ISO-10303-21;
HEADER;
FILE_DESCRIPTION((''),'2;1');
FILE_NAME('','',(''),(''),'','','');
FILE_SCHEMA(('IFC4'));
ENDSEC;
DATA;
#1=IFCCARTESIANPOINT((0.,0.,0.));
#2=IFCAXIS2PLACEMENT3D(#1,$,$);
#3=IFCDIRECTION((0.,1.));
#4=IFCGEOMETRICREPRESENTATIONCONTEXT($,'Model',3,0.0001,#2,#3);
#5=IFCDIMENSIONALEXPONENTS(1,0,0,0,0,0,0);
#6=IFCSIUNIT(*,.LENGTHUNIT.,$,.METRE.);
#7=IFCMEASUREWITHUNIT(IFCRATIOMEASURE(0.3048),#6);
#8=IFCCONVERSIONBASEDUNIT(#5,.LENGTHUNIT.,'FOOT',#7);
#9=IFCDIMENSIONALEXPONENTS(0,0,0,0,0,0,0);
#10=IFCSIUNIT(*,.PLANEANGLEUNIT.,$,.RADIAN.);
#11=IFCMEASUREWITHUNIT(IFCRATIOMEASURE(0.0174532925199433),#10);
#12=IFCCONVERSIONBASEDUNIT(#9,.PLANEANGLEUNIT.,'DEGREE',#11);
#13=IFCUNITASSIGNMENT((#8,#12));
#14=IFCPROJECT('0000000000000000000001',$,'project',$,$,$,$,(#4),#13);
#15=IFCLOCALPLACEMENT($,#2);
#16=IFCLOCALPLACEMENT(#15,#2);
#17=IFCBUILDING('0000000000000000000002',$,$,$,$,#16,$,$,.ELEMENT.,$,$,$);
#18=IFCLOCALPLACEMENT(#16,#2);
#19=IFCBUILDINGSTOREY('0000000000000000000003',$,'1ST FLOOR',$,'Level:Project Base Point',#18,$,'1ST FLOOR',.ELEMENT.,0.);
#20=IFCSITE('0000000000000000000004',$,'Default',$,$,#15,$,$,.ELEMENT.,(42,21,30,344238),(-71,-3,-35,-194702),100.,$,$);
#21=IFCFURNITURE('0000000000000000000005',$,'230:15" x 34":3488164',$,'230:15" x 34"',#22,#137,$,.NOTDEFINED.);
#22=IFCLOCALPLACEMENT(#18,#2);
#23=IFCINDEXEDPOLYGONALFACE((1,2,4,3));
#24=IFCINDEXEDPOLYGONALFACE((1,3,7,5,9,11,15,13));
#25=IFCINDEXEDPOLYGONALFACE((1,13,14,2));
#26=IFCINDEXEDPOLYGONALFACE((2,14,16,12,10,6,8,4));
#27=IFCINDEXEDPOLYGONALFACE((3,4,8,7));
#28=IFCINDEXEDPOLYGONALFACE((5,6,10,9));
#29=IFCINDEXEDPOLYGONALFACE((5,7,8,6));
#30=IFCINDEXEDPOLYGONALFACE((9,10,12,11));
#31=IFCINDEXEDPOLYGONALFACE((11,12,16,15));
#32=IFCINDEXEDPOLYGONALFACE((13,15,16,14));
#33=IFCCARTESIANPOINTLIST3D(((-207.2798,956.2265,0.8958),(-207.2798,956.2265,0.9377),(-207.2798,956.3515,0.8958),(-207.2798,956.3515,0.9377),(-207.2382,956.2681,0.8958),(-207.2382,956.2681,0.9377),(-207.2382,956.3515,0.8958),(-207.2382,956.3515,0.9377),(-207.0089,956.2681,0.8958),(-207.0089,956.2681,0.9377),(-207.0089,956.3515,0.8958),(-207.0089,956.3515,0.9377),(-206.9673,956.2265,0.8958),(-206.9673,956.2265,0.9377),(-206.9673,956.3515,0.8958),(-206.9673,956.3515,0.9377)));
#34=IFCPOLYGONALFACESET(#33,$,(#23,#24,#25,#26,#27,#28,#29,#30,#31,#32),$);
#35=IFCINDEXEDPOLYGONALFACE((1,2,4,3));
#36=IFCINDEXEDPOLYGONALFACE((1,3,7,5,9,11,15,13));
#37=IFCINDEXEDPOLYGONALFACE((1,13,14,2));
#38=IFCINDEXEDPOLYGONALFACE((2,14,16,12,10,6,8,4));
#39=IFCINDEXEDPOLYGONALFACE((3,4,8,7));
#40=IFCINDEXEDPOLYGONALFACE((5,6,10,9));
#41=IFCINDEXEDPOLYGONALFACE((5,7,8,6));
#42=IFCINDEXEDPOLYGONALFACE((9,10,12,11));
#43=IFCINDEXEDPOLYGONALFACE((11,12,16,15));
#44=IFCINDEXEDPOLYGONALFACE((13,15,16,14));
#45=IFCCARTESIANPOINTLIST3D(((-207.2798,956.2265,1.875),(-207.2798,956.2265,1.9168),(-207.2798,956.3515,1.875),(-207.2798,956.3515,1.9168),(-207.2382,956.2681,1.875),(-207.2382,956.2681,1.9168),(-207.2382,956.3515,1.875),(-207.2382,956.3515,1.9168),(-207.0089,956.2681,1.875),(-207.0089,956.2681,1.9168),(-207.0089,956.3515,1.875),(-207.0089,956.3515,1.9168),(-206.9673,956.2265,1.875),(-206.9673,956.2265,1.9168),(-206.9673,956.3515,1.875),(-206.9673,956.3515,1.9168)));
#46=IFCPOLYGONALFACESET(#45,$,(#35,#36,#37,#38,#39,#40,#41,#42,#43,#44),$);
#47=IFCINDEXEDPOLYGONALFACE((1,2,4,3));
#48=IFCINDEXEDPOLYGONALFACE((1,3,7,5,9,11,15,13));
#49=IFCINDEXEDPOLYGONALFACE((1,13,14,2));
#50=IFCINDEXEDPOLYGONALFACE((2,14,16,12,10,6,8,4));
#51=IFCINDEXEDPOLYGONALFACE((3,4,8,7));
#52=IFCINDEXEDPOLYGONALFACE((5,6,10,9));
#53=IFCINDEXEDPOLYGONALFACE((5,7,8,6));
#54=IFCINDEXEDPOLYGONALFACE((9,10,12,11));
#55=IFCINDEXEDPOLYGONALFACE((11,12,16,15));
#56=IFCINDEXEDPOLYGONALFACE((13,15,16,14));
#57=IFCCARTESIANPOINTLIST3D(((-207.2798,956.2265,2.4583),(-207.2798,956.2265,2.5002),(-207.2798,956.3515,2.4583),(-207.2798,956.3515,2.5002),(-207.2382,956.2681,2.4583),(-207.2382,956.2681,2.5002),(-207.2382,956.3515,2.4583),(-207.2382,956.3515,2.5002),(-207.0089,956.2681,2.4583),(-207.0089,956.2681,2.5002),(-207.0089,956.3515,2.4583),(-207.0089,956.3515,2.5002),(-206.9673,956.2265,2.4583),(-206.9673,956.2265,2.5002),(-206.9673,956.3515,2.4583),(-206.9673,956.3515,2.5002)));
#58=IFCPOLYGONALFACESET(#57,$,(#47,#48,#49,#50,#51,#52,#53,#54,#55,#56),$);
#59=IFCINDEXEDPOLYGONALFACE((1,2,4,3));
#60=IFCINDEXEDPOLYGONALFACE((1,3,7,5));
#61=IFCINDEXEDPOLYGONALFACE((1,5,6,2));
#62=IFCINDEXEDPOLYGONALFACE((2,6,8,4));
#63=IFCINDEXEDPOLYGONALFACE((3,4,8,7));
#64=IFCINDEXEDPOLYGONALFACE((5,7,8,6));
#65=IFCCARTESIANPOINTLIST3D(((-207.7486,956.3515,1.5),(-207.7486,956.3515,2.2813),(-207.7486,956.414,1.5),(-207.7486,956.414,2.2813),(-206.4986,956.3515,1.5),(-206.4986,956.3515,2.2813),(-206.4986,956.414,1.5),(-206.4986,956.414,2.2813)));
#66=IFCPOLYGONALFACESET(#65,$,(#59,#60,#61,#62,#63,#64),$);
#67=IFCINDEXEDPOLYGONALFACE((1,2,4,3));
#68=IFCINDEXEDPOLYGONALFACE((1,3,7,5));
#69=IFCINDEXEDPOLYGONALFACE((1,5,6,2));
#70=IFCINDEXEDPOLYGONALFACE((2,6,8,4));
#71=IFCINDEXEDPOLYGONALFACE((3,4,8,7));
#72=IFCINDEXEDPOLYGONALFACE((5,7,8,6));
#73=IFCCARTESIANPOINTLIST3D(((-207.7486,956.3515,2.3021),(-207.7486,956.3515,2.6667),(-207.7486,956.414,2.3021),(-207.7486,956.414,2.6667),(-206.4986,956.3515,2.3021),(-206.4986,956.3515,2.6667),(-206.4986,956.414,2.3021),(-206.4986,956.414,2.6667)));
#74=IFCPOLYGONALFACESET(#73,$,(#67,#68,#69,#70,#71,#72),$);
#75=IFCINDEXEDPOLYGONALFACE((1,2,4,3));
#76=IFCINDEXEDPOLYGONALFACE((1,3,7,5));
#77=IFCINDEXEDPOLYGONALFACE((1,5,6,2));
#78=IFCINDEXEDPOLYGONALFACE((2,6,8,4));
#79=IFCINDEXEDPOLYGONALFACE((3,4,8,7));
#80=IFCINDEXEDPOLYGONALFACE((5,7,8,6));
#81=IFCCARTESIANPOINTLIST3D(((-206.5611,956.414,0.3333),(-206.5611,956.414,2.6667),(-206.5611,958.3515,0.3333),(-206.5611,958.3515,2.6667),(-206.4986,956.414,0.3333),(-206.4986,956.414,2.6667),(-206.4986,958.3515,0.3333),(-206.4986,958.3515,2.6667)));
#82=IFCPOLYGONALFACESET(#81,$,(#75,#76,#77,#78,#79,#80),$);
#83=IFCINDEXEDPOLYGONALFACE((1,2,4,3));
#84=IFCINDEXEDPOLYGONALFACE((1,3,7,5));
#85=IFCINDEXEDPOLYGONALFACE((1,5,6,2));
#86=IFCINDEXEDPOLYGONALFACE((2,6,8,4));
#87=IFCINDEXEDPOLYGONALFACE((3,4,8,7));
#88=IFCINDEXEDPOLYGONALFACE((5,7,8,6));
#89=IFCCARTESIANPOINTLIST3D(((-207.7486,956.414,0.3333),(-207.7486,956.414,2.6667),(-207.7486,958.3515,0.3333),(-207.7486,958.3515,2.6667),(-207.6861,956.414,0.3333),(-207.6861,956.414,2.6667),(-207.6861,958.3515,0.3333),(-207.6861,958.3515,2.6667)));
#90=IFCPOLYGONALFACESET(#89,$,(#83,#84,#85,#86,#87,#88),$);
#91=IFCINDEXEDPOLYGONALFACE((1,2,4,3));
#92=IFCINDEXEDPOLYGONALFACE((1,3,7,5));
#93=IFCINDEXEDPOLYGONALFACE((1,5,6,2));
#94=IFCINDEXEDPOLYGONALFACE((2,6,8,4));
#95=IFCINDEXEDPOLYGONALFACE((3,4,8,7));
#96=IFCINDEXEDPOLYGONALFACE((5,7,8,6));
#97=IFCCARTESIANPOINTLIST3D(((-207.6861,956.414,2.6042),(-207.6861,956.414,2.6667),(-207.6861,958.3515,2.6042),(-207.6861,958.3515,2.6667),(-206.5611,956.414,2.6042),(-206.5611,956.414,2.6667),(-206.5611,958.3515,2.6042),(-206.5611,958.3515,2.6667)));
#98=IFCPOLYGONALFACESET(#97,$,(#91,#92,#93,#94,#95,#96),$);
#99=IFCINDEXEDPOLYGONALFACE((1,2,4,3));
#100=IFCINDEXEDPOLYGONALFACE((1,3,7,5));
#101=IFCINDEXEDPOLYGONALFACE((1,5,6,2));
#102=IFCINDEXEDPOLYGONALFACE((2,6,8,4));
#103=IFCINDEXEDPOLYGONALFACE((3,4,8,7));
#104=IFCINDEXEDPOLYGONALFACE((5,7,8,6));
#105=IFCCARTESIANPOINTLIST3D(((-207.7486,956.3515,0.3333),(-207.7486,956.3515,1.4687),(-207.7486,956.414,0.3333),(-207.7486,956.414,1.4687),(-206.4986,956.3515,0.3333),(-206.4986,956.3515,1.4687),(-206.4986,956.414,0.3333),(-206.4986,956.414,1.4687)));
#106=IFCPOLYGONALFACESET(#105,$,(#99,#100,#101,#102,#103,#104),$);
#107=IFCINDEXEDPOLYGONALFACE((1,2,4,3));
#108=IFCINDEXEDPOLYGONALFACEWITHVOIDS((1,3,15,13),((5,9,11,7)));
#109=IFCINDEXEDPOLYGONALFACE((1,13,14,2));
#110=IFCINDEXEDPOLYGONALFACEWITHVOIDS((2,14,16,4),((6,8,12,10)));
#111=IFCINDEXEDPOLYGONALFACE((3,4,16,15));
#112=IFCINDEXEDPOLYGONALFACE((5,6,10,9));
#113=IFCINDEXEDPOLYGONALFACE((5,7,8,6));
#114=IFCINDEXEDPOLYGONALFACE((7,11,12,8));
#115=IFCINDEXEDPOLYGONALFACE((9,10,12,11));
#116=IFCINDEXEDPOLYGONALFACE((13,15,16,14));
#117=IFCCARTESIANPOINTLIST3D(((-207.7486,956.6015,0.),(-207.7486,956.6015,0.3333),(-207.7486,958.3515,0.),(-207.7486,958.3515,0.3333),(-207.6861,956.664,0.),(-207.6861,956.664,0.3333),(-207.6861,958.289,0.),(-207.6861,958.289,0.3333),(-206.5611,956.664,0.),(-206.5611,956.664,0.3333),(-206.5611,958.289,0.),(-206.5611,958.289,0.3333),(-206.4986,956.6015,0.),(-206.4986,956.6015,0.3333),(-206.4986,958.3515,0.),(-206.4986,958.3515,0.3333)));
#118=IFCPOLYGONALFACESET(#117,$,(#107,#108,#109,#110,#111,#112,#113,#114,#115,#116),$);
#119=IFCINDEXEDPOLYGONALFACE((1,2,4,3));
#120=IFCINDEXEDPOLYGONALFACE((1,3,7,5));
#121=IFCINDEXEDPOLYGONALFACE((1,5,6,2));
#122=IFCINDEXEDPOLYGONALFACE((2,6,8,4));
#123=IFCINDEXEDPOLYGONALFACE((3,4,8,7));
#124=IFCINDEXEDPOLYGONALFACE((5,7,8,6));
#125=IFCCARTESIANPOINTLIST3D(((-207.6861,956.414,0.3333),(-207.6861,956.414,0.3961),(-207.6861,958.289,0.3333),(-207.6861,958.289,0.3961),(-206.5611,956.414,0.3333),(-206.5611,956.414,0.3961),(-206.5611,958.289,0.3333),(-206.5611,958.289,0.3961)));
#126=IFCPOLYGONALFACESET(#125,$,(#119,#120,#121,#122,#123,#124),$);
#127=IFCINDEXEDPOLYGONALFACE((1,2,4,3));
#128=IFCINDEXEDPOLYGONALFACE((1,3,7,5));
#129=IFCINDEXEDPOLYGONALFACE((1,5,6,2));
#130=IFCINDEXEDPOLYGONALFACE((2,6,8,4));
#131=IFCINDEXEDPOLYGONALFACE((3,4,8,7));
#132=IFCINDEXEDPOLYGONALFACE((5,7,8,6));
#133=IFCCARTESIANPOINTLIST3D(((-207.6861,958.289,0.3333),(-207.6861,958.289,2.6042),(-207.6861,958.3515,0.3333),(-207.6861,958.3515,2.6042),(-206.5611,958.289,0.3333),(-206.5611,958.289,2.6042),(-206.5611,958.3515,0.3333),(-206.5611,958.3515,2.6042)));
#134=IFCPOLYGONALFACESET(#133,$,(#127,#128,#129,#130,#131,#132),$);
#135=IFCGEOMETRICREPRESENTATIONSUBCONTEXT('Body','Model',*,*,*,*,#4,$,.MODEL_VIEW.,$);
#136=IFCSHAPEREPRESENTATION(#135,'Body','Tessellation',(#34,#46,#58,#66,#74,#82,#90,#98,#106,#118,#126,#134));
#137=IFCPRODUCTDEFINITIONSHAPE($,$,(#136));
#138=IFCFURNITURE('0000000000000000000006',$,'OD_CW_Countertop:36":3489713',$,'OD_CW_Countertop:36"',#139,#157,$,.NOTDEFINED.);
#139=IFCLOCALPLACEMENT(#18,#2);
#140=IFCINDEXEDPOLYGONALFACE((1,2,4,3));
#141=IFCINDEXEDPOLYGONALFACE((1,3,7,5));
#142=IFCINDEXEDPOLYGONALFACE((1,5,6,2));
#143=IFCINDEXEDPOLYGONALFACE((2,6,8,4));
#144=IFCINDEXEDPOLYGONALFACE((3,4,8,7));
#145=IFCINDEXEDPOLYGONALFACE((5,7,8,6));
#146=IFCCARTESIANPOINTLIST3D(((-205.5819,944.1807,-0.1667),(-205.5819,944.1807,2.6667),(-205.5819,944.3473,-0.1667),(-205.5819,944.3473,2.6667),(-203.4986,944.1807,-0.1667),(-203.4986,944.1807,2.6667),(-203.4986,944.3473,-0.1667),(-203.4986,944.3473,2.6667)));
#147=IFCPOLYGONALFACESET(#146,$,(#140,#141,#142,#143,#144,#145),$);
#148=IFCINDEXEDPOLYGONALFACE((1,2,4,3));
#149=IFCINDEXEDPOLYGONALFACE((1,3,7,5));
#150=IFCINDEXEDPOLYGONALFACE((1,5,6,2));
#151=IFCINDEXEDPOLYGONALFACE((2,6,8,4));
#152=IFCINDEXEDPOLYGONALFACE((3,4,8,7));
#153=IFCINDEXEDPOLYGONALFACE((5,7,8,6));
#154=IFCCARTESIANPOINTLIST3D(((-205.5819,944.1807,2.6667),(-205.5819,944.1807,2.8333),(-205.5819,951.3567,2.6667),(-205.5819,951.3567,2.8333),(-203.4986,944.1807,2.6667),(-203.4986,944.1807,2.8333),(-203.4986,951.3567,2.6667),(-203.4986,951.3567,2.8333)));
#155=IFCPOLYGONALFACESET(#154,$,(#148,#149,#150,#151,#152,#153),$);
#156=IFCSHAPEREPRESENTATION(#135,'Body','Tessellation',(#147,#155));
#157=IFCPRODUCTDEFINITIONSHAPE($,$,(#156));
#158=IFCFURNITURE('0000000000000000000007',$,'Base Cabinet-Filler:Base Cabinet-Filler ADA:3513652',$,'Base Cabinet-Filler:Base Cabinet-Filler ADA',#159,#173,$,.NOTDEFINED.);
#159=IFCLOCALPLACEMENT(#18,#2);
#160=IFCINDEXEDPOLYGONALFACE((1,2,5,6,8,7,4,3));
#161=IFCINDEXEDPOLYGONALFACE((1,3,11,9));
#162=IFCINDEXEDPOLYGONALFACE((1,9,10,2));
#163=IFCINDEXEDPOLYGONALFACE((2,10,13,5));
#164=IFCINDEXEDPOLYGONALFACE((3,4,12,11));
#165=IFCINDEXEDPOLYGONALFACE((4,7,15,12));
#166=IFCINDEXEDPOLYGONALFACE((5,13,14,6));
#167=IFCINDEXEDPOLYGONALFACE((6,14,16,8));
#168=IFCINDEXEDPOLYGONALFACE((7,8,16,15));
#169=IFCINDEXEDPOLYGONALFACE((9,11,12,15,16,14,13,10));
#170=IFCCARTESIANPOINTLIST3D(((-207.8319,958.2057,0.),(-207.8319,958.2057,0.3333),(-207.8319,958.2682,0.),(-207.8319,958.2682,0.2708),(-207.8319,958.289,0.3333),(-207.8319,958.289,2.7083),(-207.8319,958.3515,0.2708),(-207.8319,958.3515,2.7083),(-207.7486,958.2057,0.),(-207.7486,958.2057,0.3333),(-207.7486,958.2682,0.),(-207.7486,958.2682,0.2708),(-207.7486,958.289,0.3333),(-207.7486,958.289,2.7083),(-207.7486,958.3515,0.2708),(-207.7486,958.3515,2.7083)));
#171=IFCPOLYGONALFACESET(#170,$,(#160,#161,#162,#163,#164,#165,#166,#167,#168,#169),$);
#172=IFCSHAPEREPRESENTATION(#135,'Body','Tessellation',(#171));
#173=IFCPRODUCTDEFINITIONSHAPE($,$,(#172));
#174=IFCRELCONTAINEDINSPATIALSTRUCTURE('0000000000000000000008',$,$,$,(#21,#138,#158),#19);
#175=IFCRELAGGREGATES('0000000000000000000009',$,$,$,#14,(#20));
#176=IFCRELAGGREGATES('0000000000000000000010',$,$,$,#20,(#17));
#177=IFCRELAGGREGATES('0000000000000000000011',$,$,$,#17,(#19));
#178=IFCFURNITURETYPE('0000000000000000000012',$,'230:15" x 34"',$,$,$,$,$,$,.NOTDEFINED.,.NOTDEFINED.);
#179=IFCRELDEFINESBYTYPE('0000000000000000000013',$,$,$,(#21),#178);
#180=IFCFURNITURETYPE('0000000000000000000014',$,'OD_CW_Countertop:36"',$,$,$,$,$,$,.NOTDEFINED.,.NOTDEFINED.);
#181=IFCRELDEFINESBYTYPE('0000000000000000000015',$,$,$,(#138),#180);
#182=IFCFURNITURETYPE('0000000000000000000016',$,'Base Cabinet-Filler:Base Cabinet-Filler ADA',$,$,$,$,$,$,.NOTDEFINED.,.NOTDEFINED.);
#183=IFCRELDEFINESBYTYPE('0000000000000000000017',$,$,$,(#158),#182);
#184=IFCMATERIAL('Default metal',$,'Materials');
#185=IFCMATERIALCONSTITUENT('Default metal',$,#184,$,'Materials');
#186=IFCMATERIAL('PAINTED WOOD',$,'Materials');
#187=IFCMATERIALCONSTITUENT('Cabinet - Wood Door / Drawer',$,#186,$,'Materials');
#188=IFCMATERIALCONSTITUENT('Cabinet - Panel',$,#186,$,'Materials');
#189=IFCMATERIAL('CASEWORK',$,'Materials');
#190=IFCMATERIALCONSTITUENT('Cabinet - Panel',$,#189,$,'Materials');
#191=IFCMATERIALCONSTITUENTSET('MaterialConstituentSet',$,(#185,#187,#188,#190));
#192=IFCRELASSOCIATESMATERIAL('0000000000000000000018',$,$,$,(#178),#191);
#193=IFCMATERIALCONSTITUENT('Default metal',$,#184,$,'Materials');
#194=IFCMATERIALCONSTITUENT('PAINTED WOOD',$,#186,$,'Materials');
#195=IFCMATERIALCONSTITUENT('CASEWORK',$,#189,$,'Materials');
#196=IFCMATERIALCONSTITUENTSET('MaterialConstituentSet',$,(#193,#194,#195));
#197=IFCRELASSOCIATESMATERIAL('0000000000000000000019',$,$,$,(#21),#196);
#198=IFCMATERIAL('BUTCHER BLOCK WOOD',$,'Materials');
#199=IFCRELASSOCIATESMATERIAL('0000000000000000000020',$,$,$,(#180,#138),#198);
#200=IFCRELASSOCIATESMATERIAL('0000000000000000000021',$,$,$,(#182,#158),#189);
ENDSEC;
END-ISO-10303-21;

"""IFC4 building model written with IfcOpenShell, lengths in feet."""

from ifc_helpers import new_model, entity, si_unit, converted_unit, direction, frame, frame_2d, origin, origin_2d_with_axis, place, context, subcontext, project, spatial, polyline, rectangle, outline, extrude, source, transform, mapped, material, constituent, constituent_set, type_object, type_shapes, element, save


model = new_model("IFC4")

# Units and contexts
model_context = context("Model", 3, precision=0.0001, world=origin(), true_north=direction((0.0, 1.0)))
body_context = subcontext(model_context, "Body", "Model", "MODEL_VIEW")
ifc_project = project(units=[converted_unit("LENGTHUNIT", "FOOT", entity("IfcRatioMeasure", 0.3048), si_unit("LENGTHUNIT", "METRE"), dimensions=[1, 0, 0, 0, 0, 0, 0]), converted_unit("PLANEANGLEUNIT", "DEGREE", entity("IfcRatioMeasure", 0.0174532925199433), si_unit("PLANEANGLEUNIT", "RADIAN"), dimensions=[0, 0, 0, 0, 0, 0, 0])], contexts=[model_context])

# Site, building, storey
site_placement = place(None, origin())
site = spatial("IfcSite", under=ifc_project, at=site_placement, Name="Default", CompositionType="ELEMENT", RefLatitude=(42, 21, 30, 344238), RefLongitude=(-71, -3, -35, -194702), RefElevation=100.0)
building_placement = place(site_placement, origin())
building = spatial("IfcBuilding", under=site, at=building_placement, CompositionType="ELEMENT")
storey_placement = place(building_placement, origin())
storey = spatial("IfcBuildingStorey", under=building, at=storey_placement, Name="1ST FLOOR", ObjectType="Level:Project Base Point", LongName="1ST FLOOR", CompositionType="ELEMENT", Elevation=0.0)

# Furniture
ifc_material_1 = material(Name="Default metal", Category="Materials")
ifc_material_2 = material(Name="PAINTED WOOD", Category="Materials")
ifc_material_3 = material(Name="CASEWORK", Category="Materials")
ifc_material_4 = material(Name="BUTCHER BLOCK WOOD", Category="Materials")
ifc_constituent_1 = constituent(ifc_material_1, Name="Default metal", Category="Materials")
ifc_constituent_2 = constituent(ifc_material_2, Name="PAINTED WOOD", Category="Materials")
ifc_constituent_3 = constituent(ifc_material_3, Name="CASEWORK", Category="Materials")
ifc_constituent_set_1 = constituent_set(constituents=[ifc_constituent_1, ifc_constituent_2, ifc_constituent_3], Name="MaterialConstituentSet")
ifc_constituent_4 = constituent(ifc_material_1, Name="Default metal", Category="Materials")
ifc_constituent_5 = constituent(ifc_material_2, Name="Cabinet - Wood Door / Drawer", Category="Materials")
ifc_constituent_6 = constituent(ifc_material_2, Name="Cabinet - Panel", Category="Materials")
ifc_constituent_7 = constituent(ifc_material_3, Name="Cabinet - Panel", Category="Materials")
ifc_constituent_set_2 = constituent_set(constituents=[ifc_constituent_4, ifc_constituent_5, ifc_constituent_6, ifc_constituent_7], Name="MaterialConstituentSet")
furniture_type_1 = type_object("IfcFurnitureType", Name="230:15\" x 34\"", AssemblyPlace="NOTDEFINED", PredefinedType="NOTDEFINED", material=ifc_constituent_set_2)
shared_shape_1 = source(origin(), body_context, "Body", "SweptSolid", [
    extrude(outline(polyline([(-0.1562, -0.0521), (-0.1146, -0.0521), (-0.1146, 0.0313), (0.1146, 0.0313), (0.1146, -0.0521), (0.1562, -0.0521), (0.1562, 0.0729), (-0.1562, 0.0729), (-0.1562, -0.0521)])), frame((0.0615, 2.0521, 0.8958)), (0.0, 0.0, 1.0), 0.0418),
    extrude(outline(polyline([(-0.1562, -0.0521), (-0.1146, -0.0521), (-0.1146, 0.0313), (0.1146, 0.0313), (0.1146, -0.0521), (0.1562, -0.0521), (0.1562, 0.0729), (-0.1562, 0.0729), (-0.1562, -0.0521)])), frame((0.0615, 2.0521, 1.875)), (0.0, 0.0, 1.0), 0.0418),
    extrude(outline(polyline([(-0.1562, -0.0521), (-0.1146, -0.0521), (-0.1146, 0.0313), (0.1146, 0.0313), (0.1146, -0.0521), (0.1562, -0.0521), (0.1562, 0.0729), (-0.1562, 0.0729), (-0.1562, -0.0521)])), frame((0.0615, 2.0521, 2.4583)), (0.0, 0.0, 1.0), 0.0418),
    extrude(rectangle(XDim=1.25, YDim=0.0625, at=frame_2d((0.0, 0.0), x_axis=(1.0, 0.0))), frame((0.0615, 1.9688, 1.5), z_axis=(0.0, 0.0, 1.0), x_axis=(-1.0, 0.0, 0.0)), (0.0, 0.0, 1.0), 0.7813),
    extrude(rectangle(XDim=1.25, YDim=0.0625, at=frame_2d((0.0, 0.0), x_axis=(1.0, 0.0))), frame((0.0615, 1.9688, 2.3021), z_axis=(0.0, 0.0, 1.0), x_axis=(-1.0, 0.0, 0.0)), (0.0, 0.0, 1.0), 0.3646),
    extrude(rectangle(XDim=1.9375, YDim=0.0625, at=frame_2d((0.0, 0.0), x_axis=(1.0, 0.0))), frame((-0.5323, 0.9687, 0.3333), z_axis=(0.0, 0.0, 1.0), x_axis=(0.0, -1.0, 0.0)), (0.0, 0.0, 1.0), 2.3333),
    extrude(rectangle(XDim=1.9375, YDim=0.0625, at=frame_2d((0.0, 0.0), x_axis=(1.0, 0.0))), frame((0.6552, 0.9687, 0.3333), z_axis=(0.0, 0.0, 1.0), x_axis=(0.0, -1.0, 0.0)), (0.0, 0.0, 1.0), 2.3333),
    extrude(rectangle(XDim=1.9375, YDim=1.125, at=origin_2d_with_axis()), frame((0.0615, 0.9687, 2.6042), z_axis=(0.0, 0.0, 1.0), x_axis=(0.0, 1.0, 0.0)), (0.0, 0.0, 1.0), 0.0625),
    extrude(rectangle(XDim=1.25, YDim=0.0625, at=frame_2d((0.0, 0.0), x_axis=(1.0, 0.0))), frame((0.0615, 1.9688, 0.3333), z_axis=(0.0, 0.0, 1.0), x_axis=(-1.0, 0.0, 0.0)), (0.0, 0.0, 1.0), 1.1354),
    extrude(outline(polyline([(-0.875, -0.625), (0.875, -0.625), (0.875, 0.625), (-0.875, 0.625), (-0.875, -0.625)]), holes=[polyline([(-0.8125, -0.5625), (-0.8125, 0.5625), (0.8125, 0.5625), (0.8125, -0.5625), (-0.8125, -0.5625)])]), frame((0.0615, 0.875, 0.0), z_axis=(0.0, 0.0, 1.0), x_axis=(0.0, -1.0, 0.0)), (0.0, 0.0, 1.0), 0.3333),
    extrude(rectangle(XDim=1.875, YDim=1.125, at=origin_2d_with_axis()), frame((0.0615, 1.0, 0.3333), z_axis=(0.0, 0.0, 1.0), x_axis=(0.0, 1.0, 0.0)), (0.0, 0.0, 1.0), 0.0627),
    extrude(rectangle(XDim=1.125, YDim=0.0625, at=origin_2d_with_axis()), frame((0.0615, 0.0312, 0.3333), z_axis=(0.0, 0.0, 1.0), x_axis=(-1.0, 0.0, 0.0)), (0.0, 0.0, 1.0), 2.2708),
])
type_shapes(furniture_type_1, [shared_shape_1])
furniture_1_placement = place(storey_placement, frame((-207.0621, 958.3515, 0.0), z_axis=(0.0, 0.0, 1.0), x_axis=(-1.0, 0.0, 0.0)))
element("IfcFurniture", 1, at=furniture_1_placement, inside=storey, type_object=furniture_type_1, material=ifc_constituent_set_1, Name="230:15\" x 34\":3488164", ObjectType="230:15\" x 34\"", PredefinedType="NOTDEFINED", context=body_context, shape_type="MappedRepresentation", body=[
    mapped(shared_shape_1, transform((0.0, 0.0, 0.0), scale=1.0)),
])
furniture_type_2 = type_object("IfcFurnitureType", Name="OD_CW_Countertop:36\"", AssemblyPlace="NOTDEFINED", PredefinedType="NOTDEFINED", material=ifc_material_4)
shared_shape_2 = source(origin(), body_context, "Body", "SweptSolid", [
    extrude(rectangle(XDim=2.0833, YDim=0.1667, at=origin_2d_with_axis()), frame((7.0927, 1.0417, 0.0), z_axis=(0.0, 0.0, 1.0), x_axis=(0.0, -1.0, 0.0)), (0.0, 0.0, 1.0), 2.8333),
    extrude(rectangle(XDim=2.0833, YDim=7.176, at=origin_2d_with_axis()), frame((3.588, 1.0417, 2.8333), z_axis=(0.0, 0.0, 1.0), x_axis=(0.0, -1.0, 0.0)), (0.0, 0.0, 1.0), 0.1667),
])
type_shapes(furniture_type_2, [shared_shape_2])
furniture_2_placement = place(storey_placement, frame((-205.5819, 951.3567, -0.1667), z_axis=(0.0, 0.0, 1.0), x_axis=(0.0, -1.0, 0.0)))
element("IfcFurniture", 2, at=furniture_2_placement, inside=storey, type_object=furniture_type_2, material=ifc_material_4, Name="OD_CW_Countertop:36\":3489713", ObjectType="OD_CW_Countertop:36\"", PredefinedType="NOTDEFINED", context=body_context, shape_type="MappedRepresentation", body=[
    mapped(shared_shape_2, transform((0.0, 0.0, 0.0), scale=1.0)),
])
furniture_type_3 = type_object("IfcFurnitureType", Name="Base Cabinet-Filler:Base Cabinet-Filler ADA", AssemblyPlace="NOTDEFINED", PredefinedType="NOTDEFINED", material=ifc_material_3)
shared_shape_3 = source(origin(), body_context, "Body", "SweptSolid", [
    extrude(outline(polyline([(-0.0729, 0.5573), (-0.0729, -1.8802), (-0.0104, -1.8802), (-0.0104, 0.4948), (0.0729, 0.4948), (0.0729, 0.8281), (0.0104, 0.8281), (0.0104, 0.5573), (-0.0729, 0.5573)])), frame((0.0, 0.0729, 0.8281), z_axis=(-1.0, 0.0, 0.0), x_axis=(0.0, 1.0, 0.0)), (0.0, 0.0, -1.0), 0.0833),
])
type_shapes(furniture_type_3, [shared_shape_3])
furniture_3_placement = place(storey_placement, frame((-207.7486, 958.3515, 0.0), z_axis=(0.0, 0.0, 1.0), x_axis=(-1.0, 0.0, 0.0)))
element("IfcFurniture", 3, at=furniture_3_placement, inside=storey, type_object=furniture_type_3, material=ifc_material_3, Name="Base Cabinet-Filler:Base Cabinet-Filler ADA:3513652", ObjectType="Base Cabinet-Filler:Base Cabinet-Filler ADA", PredefinedType="NOTDEFINED", context=body_context, shape_type="MappedRepresentation", body=[
    mapped(shared_shape_3, transform((0.0, 0.0, 0.0), scale=1.0)),
])

save(model, "model.ifc")
